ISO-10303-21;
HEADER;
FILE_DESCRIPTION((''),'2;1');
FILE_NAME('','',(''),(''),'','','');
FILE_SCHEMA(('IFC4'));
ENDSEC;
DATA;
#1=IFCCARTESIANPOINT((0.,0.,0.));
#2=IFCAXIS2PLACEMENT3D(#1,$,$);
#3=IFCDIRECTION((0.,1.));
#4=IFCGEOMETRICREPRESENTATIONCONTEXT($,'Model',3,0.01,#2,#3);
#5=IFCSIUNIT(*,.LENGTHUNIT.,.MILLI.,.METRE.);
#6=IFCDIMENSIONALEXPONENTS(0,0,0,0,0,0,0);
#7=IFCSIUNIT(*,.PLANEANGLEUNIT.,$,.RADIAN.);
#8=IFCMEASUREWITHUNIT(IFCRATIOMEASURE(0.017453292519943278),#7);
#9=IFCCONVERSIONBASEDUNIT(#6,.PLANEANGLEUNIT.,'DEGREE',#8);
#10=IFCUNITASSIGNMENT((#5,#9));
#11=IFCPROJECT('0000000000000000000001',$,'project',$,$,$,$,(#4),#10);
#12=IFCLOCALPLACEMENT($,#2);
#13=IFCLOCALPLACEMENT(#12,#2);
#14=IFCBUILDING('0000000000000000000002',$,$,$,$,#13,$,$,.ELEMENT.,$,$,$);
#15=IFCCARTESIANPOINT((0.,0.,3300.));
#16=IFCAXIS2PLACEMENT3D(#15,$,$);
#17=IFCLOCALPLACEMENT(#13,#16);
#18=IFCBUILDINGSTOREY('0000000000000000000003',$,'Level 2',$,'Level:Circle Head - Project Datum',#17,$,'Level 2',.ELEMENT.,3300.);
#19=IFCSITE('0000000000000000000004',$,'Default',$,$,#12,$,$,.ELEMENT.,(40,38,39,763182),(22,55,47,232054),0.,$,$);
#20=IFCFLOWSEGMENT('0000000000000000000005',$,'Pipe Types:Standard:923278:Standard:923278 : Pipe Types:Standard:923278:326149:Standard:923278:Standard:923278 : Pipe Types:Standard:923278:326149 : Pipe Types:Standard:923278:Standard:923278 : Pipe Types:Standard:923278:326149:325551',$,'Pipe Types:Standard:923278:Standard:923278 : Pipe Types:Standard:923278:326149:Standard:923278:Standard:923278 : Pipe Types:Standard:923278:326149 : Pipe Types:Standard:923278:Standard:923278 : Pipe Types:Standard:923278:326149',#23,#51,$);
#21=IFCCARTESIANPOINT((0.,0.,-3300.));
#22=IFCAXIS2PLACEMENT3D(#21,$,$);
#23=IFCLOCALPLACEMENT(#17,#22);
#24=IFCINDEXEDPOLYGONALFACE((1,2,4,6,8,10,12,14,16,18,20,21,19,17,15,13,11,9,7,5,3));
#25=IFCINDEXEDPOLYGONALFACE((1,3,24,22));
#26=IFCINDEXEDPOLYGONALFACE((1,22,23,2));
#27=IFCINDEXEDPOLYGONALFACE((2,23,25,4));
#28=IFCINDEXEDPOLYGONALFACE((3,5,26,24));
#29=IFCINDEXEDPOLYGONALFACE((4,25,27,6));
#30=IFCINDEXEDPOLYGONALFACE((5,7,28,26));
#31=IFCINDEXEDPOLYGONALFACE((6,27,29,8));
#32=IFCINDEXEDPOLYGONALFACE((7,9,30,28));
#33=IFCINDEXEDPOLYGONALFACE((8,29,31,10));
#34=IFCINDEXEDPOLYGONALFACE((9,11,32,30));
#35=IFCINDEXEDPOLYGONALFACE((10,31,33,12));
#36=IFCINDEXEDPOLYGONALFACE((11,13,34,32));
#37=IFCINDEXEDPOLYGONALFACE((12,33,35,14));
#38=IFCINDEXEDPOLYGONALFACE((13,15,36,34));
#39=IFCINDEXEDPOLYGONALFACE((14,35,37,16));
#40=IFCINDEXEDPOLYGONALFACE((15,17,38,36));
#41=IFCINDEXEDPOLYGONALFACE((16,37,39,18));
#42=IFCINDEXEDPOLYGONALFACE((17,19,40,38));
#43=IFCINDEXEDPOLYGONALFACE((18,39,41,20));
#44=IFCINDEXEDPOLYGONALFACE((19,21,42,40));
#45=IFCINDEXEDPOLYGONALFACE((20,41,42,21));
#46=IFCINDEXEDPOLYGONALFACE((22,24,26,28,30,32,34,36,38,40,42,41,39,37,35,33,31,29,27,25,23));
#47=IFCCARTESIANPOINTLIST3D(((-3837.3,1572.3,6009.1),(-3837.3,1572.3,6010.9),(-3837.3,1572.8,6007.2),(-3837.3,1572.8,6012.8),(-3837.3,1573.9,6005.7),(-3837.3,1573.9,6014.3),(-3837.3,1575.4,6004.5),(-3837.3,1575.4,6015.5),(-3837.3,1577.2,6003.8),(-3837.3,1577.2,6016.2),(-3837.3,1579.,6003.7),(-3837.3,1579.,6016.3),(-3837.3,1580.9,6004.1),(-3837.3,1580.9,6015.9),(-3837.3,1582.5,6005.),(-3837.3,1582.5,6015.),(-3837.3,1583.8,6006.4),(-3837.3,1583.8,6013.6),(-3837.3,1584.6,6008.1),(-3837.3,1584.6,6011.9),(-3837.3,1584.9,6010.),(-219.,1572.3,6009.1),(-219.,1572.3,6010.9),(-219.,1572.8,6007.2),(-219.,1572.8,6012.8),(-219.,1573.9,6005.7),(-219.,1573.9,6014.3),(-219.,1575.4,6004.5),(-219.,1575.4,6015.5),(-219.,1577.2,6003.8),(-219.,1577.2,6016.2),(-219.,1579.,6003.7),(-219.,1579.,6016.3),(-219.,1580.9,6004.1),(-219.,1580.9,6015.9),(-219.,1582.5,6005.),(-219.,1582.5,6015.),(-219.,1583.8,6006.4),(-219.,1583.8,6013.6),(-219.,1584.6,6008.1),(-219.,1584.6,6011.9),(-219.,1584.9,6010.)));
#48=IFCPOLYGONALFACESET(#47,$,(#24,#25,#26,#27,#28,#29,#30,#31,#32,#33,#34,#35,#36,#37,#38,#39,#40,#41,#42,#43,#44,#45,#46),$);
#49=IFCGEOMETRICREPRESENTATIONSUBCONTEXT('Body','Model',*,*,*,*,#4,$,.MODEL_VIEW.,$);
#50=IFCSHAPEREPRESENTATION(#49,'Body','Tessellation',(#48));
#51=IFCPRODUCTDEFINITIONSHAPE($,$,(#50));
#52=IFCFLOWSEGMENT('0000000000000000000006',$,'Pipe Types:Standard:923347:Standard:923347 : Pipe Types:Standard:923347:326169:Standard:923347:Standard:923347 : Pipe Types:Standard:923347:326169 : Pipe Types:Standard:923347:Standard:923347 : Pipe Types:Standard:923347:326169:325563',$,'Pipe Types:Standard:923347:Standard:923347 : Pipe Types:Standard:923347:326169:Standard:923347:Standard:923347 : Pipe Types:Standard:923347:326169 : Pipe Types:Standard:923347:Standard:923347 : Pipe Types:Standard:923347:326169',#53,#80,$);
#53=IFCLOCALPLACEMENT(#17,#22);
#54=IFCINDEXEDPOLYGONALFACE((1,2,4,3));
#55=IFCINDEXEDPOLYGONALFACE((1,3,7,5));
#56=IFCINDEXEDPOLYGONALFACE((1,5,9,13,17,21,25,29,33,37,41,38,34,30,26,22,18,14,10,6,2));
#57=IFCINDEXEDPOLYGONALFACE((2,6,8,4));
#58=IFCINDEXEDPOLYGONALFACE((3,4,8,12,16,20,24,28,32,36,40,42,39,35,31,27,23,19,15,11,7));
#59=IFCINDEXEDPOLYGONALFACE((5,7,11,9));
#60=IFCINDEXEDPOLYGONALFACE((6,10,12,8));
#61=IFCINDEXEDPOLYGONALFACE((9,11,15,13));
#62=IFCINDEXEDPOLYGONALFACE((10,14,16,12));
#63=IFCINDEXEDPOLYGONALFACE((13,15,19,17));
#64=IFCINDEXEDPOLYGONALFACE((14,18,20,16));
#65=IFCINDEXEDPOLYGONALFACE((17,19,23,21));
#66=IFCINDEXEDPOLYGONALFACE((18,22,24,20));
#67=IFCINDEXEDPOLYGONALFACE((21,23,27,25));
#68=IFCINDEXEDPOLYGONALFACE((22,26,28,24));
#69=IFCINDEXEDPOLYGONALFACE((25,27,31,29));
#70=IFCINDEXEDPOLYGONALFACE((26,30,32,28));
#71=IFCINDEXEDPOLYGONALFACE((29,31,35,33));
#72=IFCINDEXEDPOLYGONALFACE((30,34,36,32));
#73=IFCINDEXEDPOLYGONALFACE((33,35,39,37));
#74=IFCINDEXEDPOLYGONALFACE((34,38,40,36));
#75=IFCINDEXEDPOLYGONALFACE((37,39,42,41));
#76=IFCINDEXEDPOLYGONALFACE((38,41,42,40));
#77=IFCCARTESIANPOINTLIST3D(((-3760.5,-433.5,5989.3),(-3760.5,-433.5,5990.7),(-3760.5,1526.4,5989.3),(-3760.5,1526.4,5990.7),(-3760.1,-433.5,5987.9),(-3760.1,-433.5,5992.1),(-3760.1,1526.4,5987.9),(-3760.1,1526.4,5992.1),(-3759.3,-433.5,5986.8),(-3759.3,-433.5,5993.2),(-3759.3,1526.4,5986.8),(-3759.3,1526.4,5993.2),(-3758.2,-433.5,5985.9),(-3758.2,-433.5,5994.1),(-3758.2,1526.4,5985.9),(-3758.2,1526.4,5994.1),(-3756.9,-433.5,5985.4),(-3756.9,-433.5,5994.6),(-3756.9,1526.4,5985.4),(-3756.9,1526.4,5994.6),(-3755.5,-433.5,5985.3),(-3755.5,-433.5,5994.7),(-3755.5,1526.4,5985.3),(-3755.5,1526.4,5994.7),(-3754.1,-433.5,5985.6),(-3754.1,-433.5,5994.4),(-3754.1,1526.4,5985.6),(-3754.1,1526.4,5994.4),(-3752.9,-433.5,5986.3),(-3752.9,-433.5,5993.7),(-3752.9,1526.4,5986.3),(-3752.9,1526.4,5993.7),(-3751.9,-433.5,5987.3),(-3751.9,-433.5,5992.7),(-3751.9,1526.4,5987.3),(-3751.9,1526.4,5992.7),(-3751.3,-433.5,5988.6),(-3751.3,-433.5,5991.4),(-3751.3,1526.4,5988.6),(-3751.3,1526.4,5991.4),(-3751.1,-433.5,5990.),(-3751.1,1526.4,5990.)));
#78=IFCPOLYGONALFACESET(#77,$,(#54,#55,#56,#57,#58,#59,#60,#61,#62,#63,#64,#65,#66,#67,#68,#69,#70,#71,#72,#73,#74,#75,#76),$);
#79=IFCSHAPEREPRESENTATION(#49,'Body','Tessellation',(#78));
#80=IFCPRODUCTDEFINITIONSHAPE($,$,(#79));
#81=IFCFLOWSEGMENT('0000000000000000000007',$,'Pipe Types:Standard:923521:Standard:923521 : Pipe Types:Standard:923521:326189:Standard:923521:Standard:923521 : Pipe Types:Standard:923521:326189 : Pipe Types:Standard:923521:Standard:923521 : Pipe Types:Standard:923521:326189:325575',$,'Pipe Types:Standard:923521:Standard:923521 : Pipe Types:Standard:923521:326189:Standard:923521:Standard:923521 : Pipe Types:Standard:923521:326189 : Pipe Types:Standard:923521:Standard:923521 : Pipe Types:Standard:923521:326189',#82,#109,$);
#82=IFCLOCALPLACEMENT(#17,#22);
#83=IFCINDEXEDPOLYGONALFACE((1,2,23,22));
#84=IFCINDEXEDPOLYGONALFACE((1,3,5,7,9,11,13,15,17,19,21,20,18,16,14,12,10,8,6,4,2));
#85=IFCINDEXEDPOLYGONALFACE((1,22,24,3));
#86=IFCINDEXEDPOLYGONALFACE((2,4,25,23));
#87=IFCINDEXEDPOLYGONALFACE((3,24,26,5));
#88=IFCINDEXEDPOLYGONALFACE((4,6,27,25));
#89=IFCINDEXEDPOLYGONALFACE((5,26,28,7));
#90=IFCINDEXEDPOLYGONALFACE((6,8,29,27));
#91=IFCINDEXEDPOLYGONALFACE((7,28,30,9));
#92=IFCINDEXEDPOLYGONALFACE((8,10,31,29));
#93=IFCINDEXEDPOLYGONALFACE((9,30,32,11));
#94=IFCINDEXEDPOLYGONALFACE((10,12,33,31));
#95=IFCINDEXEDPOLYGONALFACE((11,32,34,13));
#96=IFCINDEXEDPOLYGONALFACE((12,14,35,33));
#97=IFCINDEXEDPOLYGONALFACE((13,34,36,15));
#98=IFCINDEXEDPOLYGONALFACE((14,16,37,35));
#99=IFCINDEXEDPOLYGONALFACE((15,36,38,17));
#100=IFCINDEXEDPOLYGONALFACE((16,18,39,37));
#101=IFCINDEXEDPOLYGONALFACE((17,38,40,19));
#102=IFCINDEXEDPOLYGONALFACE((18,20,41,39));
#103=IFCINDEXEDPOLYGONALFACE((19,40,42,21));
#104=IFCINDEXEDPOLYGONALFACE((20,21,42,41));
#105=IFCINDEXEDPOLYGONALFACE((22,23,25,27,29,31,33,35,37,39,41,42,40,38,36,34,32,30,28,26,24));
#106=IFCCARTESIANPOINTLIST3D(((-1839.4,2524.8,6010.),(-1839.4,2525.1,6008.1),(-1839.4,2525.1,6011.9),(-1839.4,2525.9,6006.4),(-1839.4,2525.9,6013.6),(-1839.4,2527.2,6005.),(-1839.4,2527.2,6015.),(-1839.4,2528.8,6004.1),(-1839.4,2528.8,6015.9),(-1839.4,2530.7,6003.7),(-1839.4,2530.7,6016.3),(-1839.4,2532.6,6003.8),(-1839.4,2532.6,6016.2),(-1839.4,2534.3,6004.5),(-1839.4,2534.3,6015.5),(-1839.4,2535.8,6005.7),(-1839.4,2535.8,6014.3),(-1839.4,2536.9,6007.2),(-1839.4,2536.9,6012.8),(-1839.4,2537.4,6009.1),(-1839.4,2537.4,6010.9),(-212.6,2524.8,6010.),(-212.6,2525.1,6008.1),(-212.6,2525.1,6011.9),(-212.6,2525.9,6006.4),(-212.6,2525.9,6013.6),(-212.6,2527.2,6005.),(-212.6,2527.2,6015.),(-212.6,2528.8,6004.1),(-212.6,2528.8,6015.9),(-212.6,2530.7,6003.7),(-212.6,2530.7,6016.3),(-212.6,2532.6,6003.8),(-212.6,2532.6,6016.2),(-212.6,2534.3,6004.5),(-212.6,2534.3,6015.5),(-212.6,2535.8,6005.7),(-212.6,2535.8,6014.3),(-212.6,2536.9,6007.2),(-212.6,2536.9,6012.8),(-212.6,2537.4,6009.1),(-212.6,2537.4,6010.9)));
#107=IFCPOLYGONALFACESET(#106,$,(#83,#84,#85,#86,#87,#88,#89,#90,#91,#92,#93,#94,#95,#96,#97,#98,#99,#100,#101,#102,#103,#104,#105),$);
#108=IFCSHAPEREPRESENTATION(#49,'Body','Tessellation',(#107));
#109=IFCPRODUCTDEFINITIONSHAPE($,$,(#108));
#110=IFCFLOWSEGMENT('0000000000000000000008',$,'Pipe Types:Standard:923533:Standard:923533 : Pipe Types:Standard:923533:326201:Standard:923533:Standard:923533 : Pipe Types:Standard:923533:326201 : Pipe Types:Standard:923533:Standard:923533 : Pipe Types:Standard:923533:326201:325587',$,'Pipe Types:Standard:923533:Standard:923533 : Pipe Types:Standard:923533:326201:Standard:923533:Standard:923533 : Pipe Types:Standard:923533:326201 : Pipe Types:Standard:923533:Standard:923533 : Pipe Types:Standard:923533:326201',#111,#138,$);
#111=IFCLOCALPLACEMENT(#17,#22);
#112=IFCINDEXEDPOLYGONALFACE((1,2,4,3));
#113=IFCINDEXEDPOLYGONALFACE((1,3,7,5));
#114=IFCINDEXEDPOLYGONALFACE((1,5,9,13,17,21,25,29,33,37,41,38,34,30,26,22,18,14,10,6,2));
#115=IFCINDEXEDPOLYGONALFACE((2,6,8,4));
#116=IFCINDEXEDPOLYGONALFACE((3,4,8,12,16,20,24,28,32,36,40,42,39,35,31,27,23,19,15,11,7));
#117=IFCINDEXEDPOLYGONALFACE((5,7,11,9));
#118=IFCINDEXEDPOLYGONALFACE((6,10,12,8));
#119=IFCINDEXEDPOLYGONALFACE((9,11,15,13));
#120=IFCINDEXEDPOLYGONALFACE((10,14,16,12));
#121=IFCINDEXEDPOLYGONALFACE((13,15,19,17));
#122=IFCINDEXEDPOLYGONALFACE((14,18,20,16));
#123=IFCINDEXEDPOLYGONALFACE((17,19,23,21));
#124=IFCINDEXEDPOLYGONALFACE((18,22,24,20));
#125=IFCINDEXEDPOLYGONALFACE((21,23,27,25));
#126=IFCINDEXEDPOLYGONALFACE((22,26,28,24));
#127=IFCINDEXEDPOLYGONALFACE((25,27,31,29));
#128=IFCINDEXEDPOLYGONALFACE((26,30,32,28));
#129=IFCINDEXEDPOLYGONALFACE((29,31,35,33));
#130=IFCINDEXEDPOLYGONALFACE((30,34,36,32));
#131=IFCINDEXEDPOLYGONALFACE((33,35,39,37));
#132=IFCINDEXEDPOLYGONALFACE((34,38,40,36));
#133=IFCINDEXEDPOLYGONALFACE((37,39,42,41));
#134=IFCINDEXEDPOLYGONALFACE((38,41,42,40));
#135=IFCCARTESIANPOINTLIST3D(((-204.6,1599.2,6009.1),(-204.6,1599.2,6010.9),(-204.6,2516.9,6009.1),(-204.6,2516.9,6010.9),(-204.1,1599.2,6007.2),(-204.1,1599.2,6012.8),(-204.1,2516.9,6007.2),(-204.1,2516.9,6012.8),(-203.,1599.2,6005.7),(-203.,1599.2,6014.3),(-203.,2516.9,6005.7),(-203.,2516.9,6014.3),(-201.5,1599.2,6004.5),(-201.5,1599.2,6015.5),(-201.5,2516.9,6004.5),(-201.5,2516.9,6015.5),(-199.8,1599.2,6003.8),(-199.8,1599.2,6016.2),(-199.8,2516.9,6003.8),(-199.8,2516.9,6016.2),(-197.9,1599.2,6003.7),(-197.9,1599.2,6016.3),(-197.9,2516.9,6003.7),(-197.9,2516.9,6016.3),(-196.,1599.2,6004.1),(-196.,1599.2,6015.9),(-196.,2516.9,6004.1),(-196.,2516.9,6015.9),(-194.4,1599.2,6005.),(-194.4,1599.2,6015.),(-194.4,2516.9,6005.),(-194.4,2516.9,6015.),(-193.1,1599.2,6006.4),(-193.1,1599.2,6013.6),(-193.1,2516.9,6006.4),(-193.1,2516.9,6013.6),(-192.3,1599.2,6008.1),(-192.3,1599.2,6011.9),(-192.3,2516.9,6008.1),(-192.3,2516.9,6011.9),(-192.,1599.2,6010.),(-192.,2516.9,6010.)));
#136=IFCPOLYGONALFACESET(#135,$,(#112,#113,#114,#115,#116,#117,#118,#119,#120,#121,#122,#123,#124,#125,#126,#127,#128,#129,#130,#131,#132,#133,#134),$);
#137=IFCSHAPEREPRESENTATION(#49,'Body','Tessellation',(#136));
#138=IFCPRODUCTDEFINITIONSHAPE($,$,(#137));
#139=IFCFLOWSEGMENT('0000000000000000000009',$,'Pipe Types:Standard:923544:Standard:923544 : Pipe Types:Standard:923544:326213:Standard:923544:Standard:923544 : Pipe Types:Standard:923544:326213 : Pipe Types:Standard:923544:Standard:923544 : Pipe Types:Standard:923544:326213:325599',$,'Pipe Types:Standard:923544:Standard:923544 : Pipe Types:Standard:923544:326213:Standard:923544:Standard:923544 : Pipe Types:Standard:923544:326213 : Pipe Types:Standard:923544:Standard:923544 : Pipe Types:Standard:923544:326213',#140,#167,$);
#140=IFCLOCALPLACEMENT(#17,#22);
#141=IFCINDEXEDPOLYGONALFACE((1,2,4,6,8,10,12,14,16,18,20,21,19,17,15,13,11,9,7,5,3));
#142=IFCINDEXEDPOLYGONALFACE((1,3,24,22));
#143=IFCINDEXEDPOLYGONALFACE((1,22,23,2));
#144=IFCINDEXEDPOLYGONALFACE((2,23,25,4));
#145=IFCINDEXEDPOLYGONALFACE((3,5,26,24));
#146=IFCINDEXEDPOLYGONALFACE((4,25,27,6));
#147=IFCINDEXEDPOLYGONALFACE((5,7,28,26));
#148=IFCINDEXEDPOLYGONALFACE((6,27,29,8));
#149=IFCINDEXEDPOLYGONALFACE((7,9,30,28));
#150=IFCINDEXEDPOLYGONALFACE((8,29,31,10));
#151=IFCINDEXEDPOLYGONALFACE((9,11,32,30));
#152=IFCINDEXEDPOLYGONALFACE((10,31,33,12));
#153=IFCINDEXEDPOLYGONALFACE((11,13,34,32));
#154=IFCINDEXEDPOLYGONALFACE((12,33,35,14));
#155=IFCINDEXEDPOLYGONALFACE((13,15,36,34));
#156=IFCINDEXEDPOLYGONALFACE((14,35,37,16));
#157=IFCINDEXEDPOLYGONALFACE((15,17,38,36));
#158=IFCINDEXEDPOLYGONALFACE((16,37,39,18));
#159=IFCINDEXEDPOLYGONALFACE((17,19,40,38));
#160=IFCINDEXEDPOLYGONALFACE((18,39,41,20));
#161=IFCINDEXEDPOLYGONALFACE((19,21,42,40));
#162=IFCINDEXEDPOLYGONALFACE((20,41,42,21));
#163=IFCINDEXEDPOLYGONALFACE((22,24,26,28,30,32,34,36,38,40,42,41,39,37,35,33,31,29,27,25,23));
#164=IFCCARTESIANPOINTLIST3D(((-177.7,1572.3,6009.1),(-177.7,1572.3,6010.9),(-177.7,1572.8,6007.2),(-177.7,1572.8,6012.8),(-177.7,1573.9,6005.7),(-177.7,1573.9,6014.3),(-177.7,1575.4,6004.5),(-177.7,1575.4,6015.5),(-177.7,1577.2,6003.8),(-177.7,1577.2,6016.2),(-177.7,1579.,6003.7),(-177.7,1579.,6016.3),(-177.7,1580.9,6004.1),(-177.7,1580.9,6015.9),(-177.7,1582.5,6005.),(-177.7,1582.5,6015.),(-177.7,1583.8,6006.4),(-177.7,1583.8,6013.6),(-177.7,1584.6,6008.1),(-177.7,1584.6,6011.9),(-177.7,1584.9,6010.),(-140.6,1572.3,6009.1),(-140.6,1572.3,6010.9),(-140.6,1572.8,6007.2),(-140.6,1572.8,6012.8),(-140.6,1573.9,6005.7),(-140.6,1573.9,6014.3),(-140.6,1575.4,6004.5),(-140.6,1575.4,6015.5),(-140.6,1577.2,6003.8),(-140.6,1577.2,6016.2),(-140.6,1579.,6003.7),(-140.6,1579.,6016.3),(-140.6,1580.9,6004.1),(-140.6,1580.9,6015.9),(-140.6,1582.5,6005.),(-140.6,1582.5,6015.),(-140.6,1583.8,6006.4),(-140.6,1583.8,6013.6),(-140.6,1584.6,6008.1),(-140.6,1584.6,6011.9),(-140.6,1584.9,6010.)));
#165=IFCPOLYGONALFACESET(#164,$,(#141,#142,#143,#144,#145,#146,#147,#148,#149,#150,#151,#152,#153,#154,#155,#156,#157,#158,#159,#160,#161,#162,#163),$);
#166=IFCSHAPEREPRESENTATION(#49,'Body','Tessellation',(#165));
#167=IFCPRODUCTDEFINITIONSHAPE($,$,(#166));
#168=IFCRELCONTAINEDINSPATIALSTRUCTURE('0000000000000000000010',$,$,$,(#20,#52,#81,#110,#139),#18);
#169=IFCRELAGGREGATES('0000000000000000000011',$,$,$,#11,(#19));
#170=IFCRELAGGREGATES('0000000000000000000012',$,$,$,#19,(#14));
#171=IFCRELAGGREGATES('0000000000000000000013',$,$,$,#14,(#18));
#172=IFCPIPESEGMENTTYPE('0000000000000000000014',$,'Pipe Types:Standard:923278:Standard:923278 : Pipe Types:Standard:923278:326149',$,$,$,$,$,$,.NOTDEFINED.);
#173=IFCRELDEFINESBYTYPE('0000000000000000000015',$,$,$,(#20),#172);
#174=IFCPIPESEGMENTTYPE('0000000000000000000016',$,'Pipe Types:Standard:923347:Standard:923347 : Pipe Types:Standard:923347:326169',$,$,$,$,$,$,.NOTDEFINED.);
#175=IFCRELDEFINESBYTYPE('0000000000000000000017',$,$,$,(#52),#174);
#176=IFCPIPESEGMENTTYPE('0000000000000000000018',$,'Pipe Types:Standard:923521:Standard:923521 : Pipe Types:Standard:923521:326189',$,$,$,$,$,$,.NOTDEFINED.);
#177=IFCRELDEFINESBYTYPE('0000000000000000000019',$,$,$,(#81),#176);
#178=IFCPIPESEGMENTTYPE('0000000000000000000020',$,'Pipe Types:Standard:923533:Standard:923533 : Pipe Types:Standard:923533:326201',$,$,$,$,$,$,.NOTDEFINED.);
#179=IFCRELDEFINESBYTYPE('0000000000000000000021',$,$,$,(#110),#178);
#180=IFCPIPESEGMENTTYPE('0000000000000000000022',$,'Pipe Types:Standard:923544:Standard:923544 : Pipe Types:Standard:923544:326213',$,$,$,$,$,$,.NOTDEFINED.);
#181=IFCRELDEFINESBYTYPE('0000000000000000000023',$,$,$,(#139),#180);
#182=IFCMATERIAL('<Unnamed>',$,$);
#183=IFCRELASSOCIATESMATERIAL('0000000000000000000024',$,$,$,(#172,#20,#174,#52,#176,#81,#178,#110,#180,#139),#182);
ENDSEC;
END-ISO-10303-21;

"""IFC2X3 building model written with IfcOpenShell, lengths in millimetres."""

from ifc_helpers import new_model, entity, si_unit, converted_unit, direction, frame, origin, origin_2d_with_axis, place, context, subcontext, project, spatial, circle, extrude, source, transform, mapped, material, type_object, type_shapes, element, save


model = new_model("IFC2X3")

# Units and contexts
model_context = context("Model", 3, precision=0.01, world=origin(), true_north=direction((0.0, 1.0)))
body_context = subcontext(model_context, "Body", "Model", "MODEL_VIEW")
ifc_project = project(units=[si_unit("LENGTHUNIT", "METRE", prefix="MILLI"), converted_unit("PLANEANGLEUNIT", "DEGREE", entity("IfcRatioMeasure", 0.017453292519943278), si_unit("PLANEANGLEUNIT", "RADIAN"), dimensions=[0, 0, 0, 0, 0, 0, 0])], contexts=[model_context])

# Site, building, storey
site_placement = place(None, origin())
site = spatial("IfcSite", under=ifc_project, at=site_placement, Name="Default", CompositionType="ELEMENT", RefLatitude=(40, 38, 39, 763182), RefLongitude=(22, 55, 47, 232054), RefElevation=0.0)
building_placement = place(site_placement, origin())
building = spatial("IfcBuilding", under=site, at=building_placement, CompositionType="ELEMENT")
storey_placement = place(building_placement, frame((0.0, 0.0, 3300.0)))
storey = spatial("IfcBuildingStorey", under=building, at=storey_placement, Name="Level 2", ObjectType="Level:Circle Head - Project Datum", LongName="Level 2", CompositionType="ELEMENT", Elevation=3300.0)

# Flow segments
ifc_material = material(Name="<Unnamed>")
pipe_segment_type_1 = type_object("IfcPipeSegmentType", Name="Pipe Types:Standard:923278:Standard:923278 : Pipe Types:Standard:923278:326149", PredefinedType="NOTDEFINED", material=ifc_material)
shared_shape_1 = source(origin(), body_context, "Body", "SweptSolid", [
    extrude(circle(Radius=6.3, at=origin_2d_with_axis()), frame((-3837.3, 1578.6, 6010.0), z_axis=(1.0, 0.0, 0.0), x_axis=(0.0, 1.0, 0.0)), (0.0, 0.0, 1.0), 3618.3),
])
type_shapes(pipe_segment_type_1, [shared_shape_1])
flow_segment_1_placement = place(storey_placement, frame((0.0, 0.0, -3300.0)))
element("IfcFlowSegment", 1, at=flow_segment_1_placement, inside=storey, type_object=pipe_segment_type_1, material=ifc_material, Name="Pipe Types:Standard:923278:Standard:923278 : Pipe Types:Standard:923278:326149:Standard:923278:Standard:923278 : Pipe Types:Standard:923278:326149 : Pipe Types:Standard:923278:Standard:923278 : Pipe Types:Standard:923278:326149:325551", ObjectType="Pipe Types:Standard:923278:Standard:923278 : Pipe Types:Standard:923278:326149:Standard:923278:Standard:923278 : Pipe Types:Standard:923278:326149 : Pipe Types:Standard:923278:Standard:923278 : Pipe Types:Standard:923278:326149", context=body_context, shape_type="MappedRepresentation", body=[
    mapped(shared_shape_1, transform((0.0, 0.0, 0.0), scale=1.0)),
])
pipe_segment_type_2 = type_object("IfcPipeSegmentType", Name="Pipe Types:Standard:923347:Standard:923347 : Pipe Types:Standard:923347:326169", PredefinedType="NOTDEFINED", material=ifc_material)
shared_shape_2 = source(origin(), body_context, "Body", "SweptSolid", [
    extrude(circle(Radius=4.8, at=origin_2d_with_axis()), frame((-3755.8, -433.5, 5990.0), z_axis=(0.0, 1.0, 0.0), x_axis=(1.0, 0.0, 0.0)), (0.0, 0.0, 1.0), 1959.9),
])
type_shapes(pipe_segment_type_2, [shared_shape_2])
flow_segment_2_placement = place(storey_placement, frame((0.0, 0.0, -3300.0)))
element("IfcFlowSegment", 2, at=flow_segment_2_placement, inside=storey, type_object=pipe_segment_type_2, material=ifc_material, Name="Pipe Types:Standard:923347:Standard:923347 : Pipe Types:Standard:923347:326169:Standard:923347:Standard:923347 : Pipe Types:Standard:923347:326169 : Pipe Types:Standard:923347:Standard:923347 : Pipe Types:Standard:923347:326169:325563", ObjectType="Pipe Types:Standard:923347:Standard:923347 : Pipe Types:Standard:923347:326169:Standard:923347:Standard:923347 : Pipe Types:Standard:923347:326169 : Pipe Types:Standard:923347:Standard:923347 : Pipe Types:Standard:923347:326169", context=body_context, shape_type="MappedRepresentation", body=[
    mapped(shared_shape_2, transform((0.0, 0.0, 0.0), scale=1.0)),
])
pipe_segment_type_3 = type_object("IfcPipeSegmentType", Name="Pipe Types:Standard:923521:Standard:923521 : Pipe Types:Standard:923521:326189", PredefinedType="NOTDEFINED", material=ifc_material)
shared_shape_3 = source(origin(), body_context, "Body", "SweptSolid", [
    extrude(circle(Radius=6.3, at=origin_2d_with_axis()), frame((-1839.4, 2531.2, 6010.0), z_axis=(1.0, 0.0, 0.0), x_axis=(0.0, -1.0, 0.0)), (0.0, 0.0, 1.0), 1626.7),
])
type_shapes(pipe_segment_type_3, [shared_shape_3])
flow_segment_3_placement = place(storey_placement, frame((0.0, 0.0, -3300.0)))
element("IfcFlowSegment", 3, at=flow_segment_3_placement, inside=storey, type_object=pipe_segment_type_3, material=ifc_material, Name="Pipe Types:Standard:923521:Standard:923521 : Pipe Types:Standard:923521:326189:Standard:923521:Standard:923521 : Pipe Types:Standard:923521:326189 : Pipe Types:Standard:923521:Standard:923521 : Pipe Types:Standard:923521:326189:325575", ObjectType="Pipe Types:Standard:923521:Standard:923521 : Pipe Types:Standard:923521:326189:Standard:923521:Standard:923521 : Pipe Types:Standard:923521:326189 : Pipe Types:Standard:923521:Standard:923521 : Pipe Types:Standard:923521:326189", context=body_context, shape_type="MappedRepresentation", body=[
    mapped(shared_shape_3, transform((0.0, 0.0, 0.0), scale=1.0)),
])
pipe_segment_type_4 = type_object("IfcPipeSegmentType", Name="Pipe Types:Standard:923533:Standard:923533 : Pipe Types:Standard:923533:326201", PredefinedType="NOTDEFINED", material=ifc_material)
shared_shape_4 = source(origin(), body_context, "Body", "SweptSolid", [
    extrude(circle(Radius=6.3, at=origin_2d_with_axis()), frame((-198.4, 1599.2, 6010.0), z_axis=(0.0, 1.0, 0.0), x_axis=(1.0, 0.0, 0.0)), (0.0, 0.0, 1.0), 917.7),
])
type_shapes(pipe_segment_type_4, [shared_shape_4])
flow_segment_4_placement = place(storey_placement, frame((0.0, 0.0, -3300.0)))
element("IfcFlowSegment", 4, at=flow_segment_4_placement, inside=storey, type_object=pipe_segment_type_4, material=ifc_material, Name="Pipe Types:Standard:923533:Standard:923533 : Pipe Types:Standard:923533:326201:Standard:923533:Standard:923533 : Pipe Types:Standard:923533:326201 : Pipe Types:Standard:923533:Standard:923533 : Pipe Types:Standard:923533:326201:325587", ObjectType="Pipe Types:Standard:923533:Standard:923533 : Pipe Types:Standard:923533:326201:Standard:923533:Standard:923533 : Pipe Types:Standard:923533:326201 : Pipe Types:Standard:923533:Standard:923533 : Pipe Types:Standard:923533:326201", context=body_context, shape_type="MappedRepresentation", body=[
    mapped(shared_shape_4, transform((0.0, 0.0, 0.0), scale=1.0)),
])
pipe_segment_type_5 = type_object("IfcPipeSegmentType", Name="Pipe Types:Standard:923544:Standard:923544 : Pipe Types:Standard:923544:326213", PredefinedType="NOTDEFINED", material=ifc_material)
shared_shape_5 = source(origin(), body_context, "Body", "SweptSolid", [
    extrude(circle(Radius=6.3, at=origin_2d_with_axis()), frame((-177.7, 1578.6, 6010.0), z_axis=(1.0, 0.0, 0.0), x_axis=(0.0, 1.0, 0.0)), (0.0, 0.0, 1.0), 37.1),
])
type_shapes(pipe_segment_type_5, [shared_shape_5])
flow_segment_5_placement = place(storey_placement, frame((0.0, 0.0, -3300.0)))
element("IfcFlowSegment", 5, at=flow_segment_5_placement, inside=storey, type_object=pipe_segment_type_5, material=ifc_material, Name="Pipe Types:Standard:923544:Standard:923544 : Pipe Types:Standard:923544:326213:Standard:923544:Standard:923544 : Pipe Types:Standard:923544:326213 : Pipe Types:Standard:923544:Standard:923544 : Pipe Types:Standard:923544:326213:325599", ObjectType="Pipe Types:Standard:923544:Standard:923544 : Pipe Types:Standard:923544:326213:Standard:923544:Standard:923544 : Pipe Types:Standard:923544:326213 : Pipe Types:Standard:923544:Standard:923544 : Pipe Types:Standard:923544:326213", context=body_context, shape_type="MappedRepresentation", body=[
    mapped(shared_shape_5, transform((0.0, 0.0, 0.0), scale=1.0)),
])

save(model, "model.ifc")
